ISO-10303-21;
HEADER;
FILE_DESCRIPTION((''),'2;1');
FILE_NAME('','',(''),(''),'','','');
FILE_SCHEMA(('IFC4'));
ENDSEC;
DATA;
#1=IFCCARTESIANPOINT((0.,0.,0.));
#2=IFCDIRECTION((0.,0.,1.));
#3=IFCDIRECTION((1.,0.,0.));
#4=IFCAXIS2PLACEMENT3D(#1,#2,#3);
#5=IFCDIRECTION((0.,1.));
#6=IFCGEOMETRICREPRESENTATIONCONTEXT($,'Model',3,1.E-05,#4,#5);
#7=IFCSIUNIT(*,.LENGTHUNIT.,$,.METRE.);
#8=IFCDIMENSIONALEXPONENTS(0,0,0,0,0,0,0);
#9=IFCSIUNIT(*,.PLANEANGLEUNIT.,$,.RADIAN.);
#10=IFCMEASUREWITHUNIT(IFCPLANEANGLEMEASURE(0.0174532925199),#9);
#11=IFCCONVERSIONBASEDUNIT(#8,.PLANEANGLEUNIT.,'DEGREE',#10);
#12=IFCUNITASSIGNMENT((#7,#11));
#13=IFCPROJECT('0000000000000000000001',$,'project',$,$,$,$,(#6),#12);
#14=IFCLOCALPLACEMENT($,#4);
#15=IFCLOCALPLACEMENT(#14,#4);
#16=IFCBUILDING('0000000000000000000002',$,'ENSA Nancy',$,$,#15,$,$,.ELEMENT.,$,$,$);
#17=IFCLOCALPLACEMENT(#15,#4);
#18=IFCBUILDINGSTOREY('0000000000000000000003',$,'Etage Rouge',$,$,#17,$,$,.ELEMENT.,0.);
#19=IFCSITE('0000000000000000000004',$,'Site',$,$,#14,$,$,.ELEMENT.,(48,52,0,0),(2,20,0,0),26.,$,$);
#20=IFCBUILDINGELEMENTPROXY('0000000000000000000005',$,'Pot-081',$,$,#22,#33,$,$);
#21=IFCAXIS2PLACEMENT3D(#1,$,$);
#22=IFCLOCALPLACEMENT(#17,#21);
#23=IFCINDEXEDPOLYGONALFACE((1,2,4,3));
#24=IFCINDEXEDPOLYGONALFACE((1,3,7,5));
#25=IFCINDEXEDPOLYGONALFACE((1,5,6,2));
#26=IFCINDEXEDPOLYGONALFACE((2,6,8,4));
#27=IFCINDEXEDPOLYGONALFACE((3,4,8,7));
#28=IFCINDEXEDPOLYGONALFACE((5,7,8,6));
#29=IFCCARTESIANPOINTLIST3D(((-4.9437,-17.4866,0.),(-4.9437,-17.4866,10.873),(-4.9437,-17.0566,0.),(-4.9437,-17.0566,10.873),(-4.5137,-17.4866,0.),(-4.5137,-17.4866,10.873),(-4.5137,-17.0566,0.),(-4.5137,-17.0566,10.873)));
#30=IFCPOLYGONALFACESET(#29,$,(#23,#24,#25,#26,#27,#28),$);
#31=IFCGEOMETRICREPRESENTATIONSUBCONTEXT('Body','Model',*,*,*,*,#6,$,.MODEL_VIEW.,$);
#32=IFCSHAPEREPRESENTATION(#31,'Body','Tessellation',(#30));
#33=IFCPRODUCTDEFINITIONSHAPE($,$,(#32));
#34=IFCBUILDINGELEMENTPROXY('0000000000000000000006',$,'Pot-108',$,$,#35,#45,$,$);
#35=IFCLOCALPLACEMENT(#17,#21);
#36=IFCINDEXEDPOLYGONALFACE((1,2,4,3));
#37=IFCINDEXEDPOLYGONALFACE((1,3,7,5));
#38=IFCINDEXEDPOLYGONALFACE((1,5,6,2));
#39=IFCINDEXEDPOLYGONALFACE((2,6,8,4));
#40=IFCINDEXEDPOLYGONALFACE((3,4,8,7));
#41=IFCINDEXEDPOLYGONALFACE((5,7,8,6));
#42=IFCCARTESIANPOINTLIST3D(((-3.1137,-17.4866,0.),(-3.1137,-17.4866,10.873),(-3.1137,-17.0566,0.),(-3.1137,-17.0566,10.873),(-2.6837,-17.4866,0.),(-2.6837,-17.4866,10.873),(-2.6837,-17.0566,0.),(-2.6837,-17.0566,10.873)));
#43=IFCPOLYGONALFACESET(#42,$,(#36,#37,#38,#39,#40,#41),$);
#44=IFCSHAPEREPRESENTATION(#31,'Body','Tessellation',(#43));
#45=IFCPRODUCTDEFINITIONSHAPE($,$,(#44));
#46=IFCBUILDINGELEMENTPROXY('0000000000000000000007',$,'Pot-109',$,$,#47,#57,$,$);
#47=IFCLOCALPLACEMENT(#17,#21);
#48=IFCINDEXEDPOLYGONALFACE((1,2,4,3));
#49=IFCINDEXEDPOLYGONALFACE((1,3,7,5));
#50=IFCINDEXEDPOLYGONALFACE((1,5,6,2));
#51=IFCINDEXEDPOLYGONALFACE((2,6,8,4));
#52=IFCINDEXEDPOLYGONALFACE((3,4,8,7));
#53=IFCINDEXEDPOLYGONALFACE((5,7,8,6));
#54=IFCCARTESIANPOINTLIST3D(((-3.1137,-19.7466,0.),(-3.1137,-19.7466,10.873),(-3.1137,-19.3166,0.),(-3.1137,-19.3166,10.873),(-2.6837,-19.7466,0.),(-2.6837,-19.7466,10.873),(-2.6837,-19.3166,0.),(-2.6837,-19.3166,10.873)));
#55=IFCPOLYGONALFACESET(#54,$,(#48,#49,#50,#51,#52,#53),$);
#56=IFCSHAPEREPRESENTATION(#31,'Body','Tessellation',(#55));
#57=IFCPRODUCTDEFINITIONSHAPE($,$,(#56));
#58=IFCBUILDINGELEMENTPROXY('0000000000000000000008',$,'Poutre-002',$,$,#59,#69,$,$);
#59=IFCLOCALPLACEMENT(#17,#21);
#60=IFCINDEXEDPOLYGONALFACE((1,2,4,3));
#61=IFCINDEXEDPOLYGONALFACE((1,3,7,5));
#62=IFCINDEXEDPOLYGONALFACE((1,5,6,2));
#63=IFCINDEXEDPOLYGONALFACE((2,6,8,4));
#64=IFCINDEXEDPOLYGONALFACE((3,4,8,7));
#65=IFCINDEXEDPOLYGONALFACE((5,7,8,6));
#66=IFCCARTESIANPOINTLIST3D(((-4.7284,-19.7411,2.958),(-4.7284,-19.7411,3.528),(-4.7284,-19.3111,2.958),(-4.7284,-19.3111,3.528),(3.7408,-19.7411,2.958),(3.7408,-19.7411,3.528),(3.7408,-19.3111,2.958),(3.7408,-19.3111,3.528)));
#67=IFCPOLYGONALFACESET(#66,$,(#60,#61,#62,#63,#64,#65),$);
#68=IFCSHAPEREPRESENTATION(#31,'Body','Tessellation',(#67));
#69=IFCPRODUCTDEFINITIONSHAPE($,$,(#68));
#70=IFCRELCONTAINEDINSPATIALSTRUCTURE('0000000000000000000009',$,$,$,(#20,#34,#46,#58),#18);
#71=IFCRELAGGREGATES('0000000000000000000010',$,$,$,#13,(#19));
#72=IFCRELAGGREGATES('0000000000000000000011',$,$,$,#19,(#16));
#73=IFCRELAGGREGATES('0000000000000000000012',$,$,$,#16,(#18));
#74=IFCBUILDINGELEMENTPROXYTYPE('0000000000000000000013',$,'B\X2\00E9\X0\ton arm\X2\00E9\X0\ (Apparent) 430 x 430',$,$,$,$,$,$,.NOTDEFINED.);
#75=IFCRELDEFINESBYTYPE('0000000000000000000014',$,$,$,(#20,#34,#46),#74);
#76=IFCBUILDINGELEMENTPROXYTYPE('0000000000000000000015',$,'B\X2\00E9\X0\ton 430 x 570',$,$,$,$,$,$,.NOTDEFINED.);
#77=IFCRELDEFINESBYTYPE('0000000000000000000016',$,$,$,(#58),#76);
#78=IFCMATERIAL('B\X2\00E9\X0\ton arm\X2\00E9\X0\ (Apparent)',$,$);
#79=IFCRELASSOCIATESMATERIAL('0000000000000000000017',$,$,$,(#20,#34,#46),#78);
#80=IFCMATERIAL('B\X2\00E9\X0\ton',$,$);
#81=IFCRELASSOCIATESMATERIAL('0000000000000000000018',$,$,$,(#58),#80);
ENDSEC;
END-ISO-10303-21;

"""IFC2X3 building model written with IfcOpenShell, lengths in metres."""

from ifc_helpers import new_model, entity, si_unit, converted_unit, direction, frame, frame_2d, origin_with_axes, origin_2d_with_axis, place, context, subcontext, project, spatial, rectangle, extrude, material, type_object, element, save


model = new_model("IFC2X3")

# Units and contexts
model_context = context("Model", 3, precision=1e-05, world=origin_with_axes(), true_north=direction((0.0, 1.0)))
body_context = subcontext(model_context, "Body", "Model", "MODEL_VIEW")
ifc_project = project(units=[si_unit("LENGTHUNIT", "METRE"), converted_unit("PLANEANGLEUNIT", "DEGREE", entity("IfcPlaneAngleMeasure", 0.0174532925199), si_unit("PLANEANGLEUNIT", "RADIAN"), dimensions=[0, 0, 0, 0, 0, 0, 0])], contexts=[model_context])

# Site, building, storey
site_placement = place(None, origin_with_axes())
site = spatial("IfcSite", under=ifc_project, at=site_placement, Name="Site", CompositionType="ELEMENT", RefLatitude=(48, 52, 0, 0), RefLongitude=(2, 20, 0, 0), RefElevation=26.0)
building_placement = place(site_placement, origin_with_axes())
building = spatial("IfcBuilding", under=site, at=building_placement, Name="ENSA Nancy", CompositionType="ELEMENT")
storey_placement = place(building_placement, origin_with_axes())
storey = spatial("IfcBuildingStorey", under=building, at=storey_placement, Name="Etage Rouge", CompositionType="ELEMENT", Elevation=0.0)

# Building element proxies
ifc_material_1 = material(Name="Béton")
ifc_material_2 = material(Name="Béton armé (Apparent)")
building_element_proxy_type_1 = type_object("IfcBuildingElementProxyType", Name="Béton armé (Apparent) 430 x 430", PredefinedType="NOTDEFINED")
for number, where, z_axis, x_axis, name in (
    (1, (-4.7287, -17.2716, 0.0), (0.0, 0.0, 1.0), (1.0, 0.0, 0.0), "Pot-081"),
    (2, (-2.8987, -17.2716, 0.0), (0.0, 0.0, 1.0), (1.0, 0.0, 0.0), "Pot-108"),
    (3, (-2.8987, -19.5316, 0.0), (0.0, 0.0, 1.0), (1.0, 0.0, 0.0), "Pot-109"),
):
    element("IfcBuildingElementProxy", number, at=place(storey_placement, frame(where, z_axis=z_axis, x_axis=x_axis)), inside=storey, type_object=building_element_proxy_type_1, material=ifc_material_2, Name=name, context=body_context, shape_type="SweptSolid", body=[
        extrude(rectangle(XDim=0.43, YDim=0.43, at=origin_2d_with_axis()), origin_with_axes(), (0.0, 0.0, 1.0), 10.873),
    ])
building_element_proxy_type_2 = type_object("IfcBuildingElementProxyType", Name="Béton 430 x 570", PredefinedType="NOTDEFINED")
proxy_1_placement = place(storey_placement, frame((-4.7284, -19.5261, 3.528), z_axis=(0.0, 0.0, 1.0), x_axis=(0.0, -1.0, 0.0)))
element("IfcBuildingElementProxy", 4, at=proxy_1_placement, inside=storey, type_object=building_element_proxy_type_2, material=ifc_material_1, Name="Poutre-002", context=body_context, shape_type="SweptSolid", body=[
    extrude(rectangle(XDim=0.57, YDim=0.43, at=frame_2d((-0.285, 0.0), x_axis=(1.0, 0.0))), frame((0.0, 0.0, 0.0), z_axis=(0.0, 1.0, 0.0), x_axis=(0.0, 0.0, 1.0)), (0.0, 0.0, 1.0), 8.4691),
])

save(model, "model.ifc")
